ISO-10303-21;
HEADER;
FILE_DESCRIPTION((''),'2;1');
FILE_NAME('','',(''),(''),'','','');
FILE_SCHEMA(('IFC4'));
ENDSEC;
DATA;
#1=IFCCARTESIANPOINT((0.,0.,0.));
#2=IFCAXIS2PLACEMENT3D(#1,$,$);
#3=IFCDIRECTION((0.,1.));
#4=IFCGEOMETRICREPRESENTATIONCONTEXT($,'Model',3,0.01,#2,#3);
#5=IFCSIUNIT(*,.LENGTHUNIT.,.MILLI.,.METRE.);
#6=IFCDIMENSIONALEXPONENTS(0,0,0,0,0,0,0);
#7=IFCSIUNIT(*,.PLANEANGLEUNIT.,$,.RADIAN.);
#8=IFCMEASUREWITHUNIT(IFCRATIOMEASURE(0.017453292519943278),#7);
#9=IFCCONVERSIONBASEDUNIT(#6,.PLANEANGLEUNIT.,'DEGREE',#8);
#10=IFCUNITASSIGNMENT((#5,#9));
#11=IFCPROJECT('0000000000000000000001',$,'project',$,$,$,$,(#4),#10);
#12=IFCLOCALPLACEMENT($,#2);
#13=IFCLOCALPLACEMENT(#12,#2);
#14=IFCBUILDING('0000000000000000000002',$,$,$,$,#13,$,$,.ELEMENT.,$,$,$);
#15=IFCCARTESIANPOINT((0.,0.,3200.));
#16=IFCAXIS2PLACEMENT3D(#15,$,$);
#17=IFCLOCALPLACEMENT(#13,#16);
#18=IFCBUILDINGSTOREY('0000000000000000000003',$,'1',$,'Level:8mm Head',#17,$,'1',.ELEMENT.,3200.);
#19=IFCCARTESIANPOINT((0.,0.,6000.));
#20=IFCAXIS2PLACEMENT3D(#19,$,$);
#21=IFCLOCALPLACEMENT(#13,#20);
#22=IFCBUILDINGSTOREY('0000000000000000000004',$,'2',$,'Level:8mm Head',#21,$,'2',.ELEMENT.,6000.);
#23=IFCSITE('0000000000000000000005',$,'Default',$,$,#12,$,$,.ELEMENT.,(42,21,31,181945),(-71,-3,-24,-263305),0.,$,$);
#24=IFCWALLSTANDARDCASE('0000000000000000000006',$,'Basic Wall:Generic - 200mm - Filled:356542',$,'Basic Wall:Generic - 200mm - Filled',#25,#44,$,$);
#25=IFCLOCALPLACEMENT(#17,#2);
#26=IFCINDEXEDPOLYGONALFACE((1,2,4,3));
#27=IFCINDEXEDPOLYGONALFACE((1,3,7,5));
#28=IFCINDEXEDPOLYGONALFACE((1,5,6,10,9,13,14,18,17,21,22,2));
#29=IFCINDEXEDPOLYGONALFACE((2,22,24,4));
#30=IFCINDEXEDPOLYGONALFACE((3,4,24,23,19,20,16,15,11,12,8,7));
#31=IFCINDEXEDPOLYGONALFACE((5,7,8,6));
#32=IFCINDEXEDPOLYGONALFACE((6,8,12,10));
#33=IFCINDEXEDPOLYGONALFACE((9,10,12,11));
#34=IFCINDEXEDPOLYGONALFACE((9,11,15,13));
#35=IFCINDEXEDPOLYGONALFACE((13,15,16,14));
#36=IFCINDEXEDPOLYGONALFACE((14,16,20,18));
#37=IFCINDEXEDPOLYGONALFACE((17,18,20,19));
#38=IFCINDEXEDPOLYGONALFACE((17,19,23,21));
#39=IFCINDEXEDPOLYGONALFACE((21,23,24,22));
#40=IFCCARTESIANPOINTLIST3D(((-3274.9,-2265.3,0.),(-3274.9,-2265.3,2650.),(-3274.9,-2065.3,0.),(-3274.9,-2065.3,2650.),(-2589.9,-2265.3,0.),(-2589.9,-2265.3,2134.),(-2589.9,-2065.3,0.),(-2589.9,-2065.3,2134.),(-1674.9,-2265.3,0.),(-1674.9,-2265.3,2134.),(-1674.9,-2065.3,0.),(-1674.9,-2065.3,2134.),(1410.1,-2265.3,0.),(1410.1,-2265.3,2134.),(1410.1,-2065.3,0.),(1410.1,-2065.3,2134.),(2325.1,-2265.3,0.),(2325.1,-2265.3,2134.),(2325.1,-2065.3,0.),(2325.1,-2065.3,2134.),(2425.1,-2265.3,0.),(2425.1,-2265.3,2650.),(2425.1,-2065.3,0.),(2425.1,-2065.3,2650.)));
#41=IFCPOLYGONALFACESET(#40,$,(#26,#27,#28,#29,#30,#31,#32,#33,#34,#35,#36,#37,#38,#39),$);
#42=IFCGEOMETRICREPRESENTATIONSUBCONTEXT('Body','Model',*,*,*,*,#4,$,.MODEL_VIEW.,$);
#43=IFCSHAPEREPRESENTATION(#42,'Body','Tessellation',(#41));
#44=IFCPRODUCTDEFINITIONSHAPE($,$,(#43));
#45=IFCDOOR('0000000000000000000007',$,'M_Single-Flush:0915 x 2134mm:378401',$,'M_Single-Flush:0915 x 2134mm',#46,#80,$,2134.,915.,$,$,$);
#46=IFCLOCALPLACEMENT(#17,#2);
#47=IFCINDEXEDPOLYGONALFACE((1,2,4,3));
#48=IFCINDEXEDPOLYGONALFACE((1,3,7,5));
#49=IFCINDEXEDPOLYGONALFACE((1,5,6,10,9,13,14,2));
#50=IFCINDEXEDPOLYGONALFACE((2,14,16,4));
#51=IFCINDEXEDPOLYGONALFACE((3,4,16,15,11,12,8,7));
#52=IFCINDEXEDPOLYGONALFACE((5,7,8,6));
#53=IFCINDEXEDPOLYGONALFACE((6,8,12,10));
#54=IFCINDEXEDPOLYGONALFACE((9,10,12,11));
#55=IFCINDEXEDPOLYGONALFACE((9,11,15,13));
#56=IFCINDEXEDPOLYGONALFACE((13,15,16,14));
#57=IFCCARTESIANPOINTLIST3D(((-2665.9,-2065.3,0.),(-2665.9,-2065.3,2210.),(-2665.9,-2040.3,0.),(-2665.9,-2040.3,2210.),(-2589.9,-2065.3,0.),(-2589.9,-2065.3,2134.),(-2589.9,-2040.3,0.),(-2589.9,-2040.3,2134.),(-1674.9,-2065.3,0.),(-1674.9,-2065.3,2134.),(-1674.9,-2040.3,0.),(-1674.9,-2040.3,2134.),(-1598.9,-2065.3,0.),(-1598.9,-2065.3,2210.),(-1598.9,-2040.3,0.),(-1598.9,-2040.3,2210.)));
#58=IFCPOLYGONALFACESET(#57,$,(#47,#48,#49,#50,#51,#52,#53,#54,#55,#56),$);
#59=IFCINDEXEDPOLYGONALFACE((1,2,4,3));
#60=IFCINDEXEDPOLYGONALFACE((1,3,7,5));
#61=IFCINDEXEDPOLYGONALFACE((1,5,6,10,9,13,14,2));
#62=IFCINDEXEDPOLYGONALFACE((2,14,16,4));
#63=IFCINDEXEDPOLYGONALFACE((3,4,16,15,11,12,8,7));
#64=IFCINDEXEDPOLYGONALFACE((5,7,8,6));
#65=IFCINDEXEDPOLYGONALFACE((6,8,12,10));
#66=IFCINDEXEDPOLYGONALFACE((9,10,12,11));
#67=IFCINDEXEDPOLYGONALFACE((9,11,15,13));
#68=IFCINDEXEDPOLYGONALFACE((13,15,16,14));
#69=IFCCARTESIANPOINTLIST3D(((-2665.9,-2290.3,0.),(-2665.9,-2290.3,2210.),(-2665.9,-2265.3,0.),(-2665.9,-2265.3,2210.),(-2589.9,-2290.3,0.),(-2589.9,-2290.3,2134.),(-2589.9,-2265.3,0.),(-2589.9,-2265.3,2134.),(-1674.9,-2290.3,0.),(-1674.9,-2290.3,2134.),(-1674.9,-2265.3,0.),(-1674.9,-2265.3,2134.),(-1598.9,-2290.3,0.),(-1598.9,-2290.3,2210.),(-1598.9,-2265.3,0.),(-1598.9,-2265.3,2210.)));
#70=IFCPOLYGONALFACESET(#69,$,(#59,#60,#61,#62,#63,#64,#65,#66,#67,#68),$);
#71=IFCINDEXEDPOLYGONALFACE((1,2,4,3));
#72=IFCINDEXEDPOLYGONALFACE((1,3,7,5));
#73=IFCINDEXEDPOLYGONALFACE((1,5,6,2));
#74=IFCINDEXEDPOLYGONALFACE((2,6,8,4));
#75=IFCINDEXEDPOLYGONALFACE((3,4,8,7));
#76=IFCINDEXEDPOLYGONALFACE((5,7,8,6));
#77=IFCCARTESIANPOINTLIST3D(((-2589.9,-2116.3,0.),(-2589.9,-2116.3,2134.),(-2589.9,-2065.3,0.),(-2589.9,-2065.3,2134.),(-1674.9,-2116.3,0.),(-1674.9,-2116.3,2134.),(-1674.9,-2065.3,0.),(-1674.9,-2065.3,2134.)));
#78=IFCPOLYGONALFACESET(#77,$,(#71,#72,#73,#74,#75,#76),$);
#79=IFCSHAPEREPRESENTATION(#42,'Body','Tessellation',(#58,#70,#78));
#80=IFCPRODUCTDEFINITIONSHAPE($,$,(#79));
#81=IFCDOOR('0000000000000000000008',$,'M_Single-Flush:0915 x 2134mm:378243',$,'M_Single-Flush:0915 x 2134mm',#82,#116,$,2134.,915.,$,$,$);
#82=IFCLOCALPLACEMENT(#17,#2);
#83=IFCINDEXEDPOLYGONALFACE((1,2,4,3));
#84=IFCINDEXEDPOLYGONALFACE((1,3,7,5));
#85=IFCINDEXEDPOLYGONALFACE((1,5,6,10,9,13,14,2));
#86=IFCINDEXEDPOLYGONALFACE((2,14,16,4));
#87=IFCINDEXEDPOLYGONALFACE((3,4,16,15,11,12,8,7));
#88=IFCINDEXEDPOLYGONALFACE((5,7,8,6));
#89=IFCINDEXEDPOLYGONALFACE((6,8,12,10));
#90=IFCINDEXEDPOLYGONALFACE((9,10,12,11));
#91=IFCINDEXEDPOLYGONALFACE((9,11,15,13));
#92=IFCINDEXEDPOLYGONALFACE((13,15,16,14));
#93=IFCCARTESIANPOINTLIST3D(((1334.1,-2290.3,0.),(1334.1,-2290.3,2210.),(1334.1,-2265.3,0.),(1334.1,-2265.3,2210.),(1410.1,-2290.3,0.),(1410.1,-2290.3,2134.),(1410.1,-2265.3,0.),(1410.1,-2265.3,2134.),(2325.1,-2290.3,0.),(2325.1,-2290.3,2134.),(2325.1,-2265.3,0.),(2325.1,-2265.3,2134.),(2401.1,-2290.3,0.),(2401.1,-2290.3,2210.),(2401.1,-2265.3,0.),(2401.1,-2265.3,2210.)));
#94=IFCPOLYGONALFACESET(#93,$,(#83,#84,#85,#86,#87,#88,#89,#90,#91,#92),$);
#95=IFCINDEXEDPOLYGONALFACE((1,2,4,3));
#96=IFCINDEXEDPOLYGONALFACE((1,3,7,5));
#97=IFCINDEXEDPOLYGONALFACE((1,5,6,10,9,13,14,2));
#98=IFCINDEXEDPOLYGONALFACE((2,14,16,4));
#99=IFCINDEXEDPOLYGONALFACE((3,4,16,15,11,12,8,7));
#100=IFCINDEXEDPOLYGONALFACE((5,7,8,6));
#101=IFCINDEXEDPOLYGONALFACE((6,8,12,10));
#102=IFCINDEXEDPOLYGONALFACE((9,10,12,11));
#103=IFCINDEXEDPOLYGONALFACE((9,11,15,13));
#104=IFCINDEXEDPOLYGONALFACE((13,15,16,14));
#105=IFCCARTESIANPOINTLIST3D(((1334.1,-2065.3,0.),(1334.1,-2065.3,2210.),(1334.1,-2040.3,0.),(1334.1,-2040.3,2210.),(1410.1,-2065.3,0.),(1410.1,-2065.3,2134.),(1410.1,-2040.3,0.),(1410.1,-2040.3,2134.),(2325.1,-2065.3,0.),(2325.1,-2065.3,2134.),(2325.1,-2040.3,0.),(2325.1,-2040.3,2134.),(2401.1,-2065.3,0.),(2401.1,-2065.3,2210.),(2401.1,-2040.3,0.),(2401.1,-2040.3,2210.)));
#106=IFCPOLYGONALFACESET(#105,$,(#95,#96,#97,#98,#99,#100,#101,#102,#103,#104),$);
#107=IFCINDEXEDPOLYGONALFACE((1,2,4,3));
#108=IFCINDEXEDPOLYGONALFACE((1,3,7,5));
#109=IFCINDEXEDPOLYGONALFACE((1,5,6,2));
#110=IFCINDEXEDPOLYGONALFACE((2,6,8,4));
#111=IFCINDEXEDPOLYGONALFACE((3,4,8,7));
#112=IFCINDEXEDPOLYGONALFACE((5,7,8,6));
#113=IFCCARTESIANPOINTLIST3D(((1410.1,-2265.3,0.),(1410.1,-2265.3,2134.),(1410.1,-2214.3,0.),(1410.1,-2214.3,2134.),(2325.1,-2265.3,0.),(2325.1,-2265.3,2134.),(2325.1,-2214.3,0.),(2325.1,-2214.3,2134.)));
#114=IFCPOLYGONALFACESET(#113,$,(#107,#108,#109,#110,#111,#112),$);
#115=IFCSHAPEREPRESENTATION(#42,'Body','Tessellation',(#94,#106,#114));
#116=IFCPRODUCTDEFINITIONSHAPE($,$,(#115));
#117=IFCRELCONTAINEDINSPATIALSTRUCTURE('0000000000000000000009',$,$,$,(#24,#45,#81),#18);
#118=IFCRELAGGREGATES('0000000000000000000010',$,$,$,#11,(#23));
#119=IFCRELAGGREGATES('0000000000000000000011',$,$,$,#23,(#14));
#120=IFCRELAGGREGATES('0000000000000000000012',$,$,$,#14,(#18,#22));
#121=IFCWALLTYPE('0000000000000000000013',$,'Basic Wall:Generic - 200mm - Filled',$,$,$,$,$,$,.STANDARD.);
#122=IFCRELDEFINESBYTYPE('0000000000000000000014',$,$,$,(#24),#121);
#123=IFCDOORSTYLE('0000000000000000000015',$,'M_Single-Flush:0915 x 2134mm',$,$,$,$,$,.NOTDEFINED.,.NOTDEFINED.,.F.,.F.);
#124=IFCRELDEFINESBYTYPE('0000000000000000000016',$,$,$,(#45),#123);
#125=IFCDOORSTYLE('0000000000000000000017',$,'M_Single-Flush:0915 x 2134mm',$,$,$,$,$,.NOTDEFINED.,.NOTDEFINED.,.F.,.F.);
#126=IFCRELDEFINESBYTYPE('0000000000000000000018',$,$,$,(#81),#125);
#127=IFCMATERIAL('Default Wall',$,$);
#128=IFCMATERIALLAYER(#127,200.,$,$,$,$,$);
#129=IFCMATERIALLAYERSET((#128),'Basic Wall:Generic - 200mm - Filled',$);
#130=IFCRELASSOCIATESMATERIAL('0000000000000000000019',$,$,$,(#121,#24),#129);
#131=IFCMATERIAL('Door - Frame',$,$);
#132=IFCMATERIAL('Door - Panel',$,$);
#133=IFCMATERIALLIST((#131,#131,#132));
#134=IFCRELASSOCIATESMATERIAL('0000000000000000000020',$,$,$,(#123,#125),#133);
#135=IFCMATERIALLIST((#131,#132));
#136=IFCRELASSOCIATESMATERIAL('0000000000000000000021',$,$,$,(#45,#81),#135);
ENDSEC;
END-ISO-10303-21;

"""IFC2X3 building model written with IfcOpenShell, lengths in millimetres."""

from ifc_helpers import new_model, entity, si_unit, converted_unit, direction, frame, frame_2d, origin, place, context, subcontext, project, spatial, polyline, rectangle, outline, extrude, clip, bounded_halfspace, source, transform, mapped, material, material_list, layer, layer_set, layer_usage, type_object, type_shapes, element, fill, save


model = new_model("IFC2X3")

# Units and contexts
model_context = context("Model", 3, precision=0.01, world=origin(), true_north=direction((0.0, 1.0)))
body_context = subcontext(model_context, "Body", "Model", "MODEL_VIEW")
ifc_project = project(units=[si_unit("LENGTHUNIT", "METRE", prefix="MILLI"), converted_unit("PLANEANGLEUNIT", "DEGREE", entity("IfcRatioMeasure", 0.017453292519943278), si_unit("PLANEANGLEUNIT", "RADIAN"), dimensions=[0, 0, 0, 0, 0, 0, 0])], contexts=[model_context])

# Site, building, storey
site_placement = place(None, origin())
site = spatial("IfcSite", under=ifc_project, at=site_placement, Name="Default", CompositionType="ELEMENT", RefLatitude=(42, 21, 31, 181945), RefLongitude=(-71, -3, -24, -263305), RefElevation=0.0)
building_placement = place(site_placement, origin())
building = spatial("IfcBuilding", under=site, at=building_placement, CompositionType="ELEMENT")
storey_1_placement = place(building_placement, frame((0.0, 0.0, 3200.0)))
storey_1 = spatial("IfcBuildingStorey", under=building, at=storey_1_placement, Name="1", ObjectType="Level:8mm Head", LongName="1", CompositionType="ELEMENT", Elevation=3200.0)

# Shared definitions
ifc_material_1 = material(Name="Default Wall")

# Shared definitions
storey_2_placement = place(building_placement, frame((0.0, 0.0, 6000.0)))
storey_2 = spatial("IfcBuildingStorey", under=building, at=storey_2_placement, Name="2", ObjectType="Level:8mm Head", LongName="2", CompositionType="ELEMENT", Elevation=6000.0)

# Shared definitions
ifc_layer_1 = layer(ifc_material_1, 200.0)
ifc_layer_set_1 = layer_set([ifc_layer_1], Name="Basic Wall:Generic - 200mm - Filled")
ifc_layer_usage_1 = layer_usage(ifc_layer_set_1, "AXIS2", "NEGATIVE", 100.0)
wall_type_1 = type_object("IfcWallType", Name="Basic Wall:Generic - 200mm - Filled", PredefinedType="STANDARD", material=ifc_layer_set_1)

# Wall, openings, doors
wall_1_placement = place(storey_1_placement, frame((2425.1, -2165.3, 0.0), z_axis=(0.0, 0.0, 1.0), x_axis=(-1.0, 0.0, 0.0)))
wall_1 = element("IfcWallStandardCase", 1, at=wall_1_placement, inside=storey_1, type_object=wall_type_1, material=ifc_layer_usage_1, Name="Basic Wall:Generic - 200mm - Filled:356542", ObjectType="Basic Wall:Generic - 200mm - Filled", context=body_context, shape_type="Clipping", body=[
    clip(extrude(rectangle(XDim=5700.0, YDim=200.0, at=frame_2d((2850.0, 0.0), x_axis=(1.0, 0.0))), origin(), (0.0, 0.0, 1.0), 2650.0), bounded_halfspace(frame((0.0, -100.0, 2650.0), z_axis=(0.0, 0.0, -1.0), x_axis=(0.0, 1.0, 0.0)), True, frame((0.0, -100.0, 2650.0)), polyline([(0.0, 0.0), (1737360.0, 0.0), (1737360.0, 60960.0), (1036320.0, 60960.0), (975360.0, 60960.0), (365760.0, 60960.0), (335280.0, 60960.0), (0.0, 60960.0), (0.0, 0.0)]))),
])
opening_1_placement = place(wall_1_placement, frame((100.0, -100.0, 0.0)))
opening_1 = element("IfcOpeningElement", 2, at=opening_1_placement, cuts=wall_1, ObjectType="Opening", context=body_context, shape_type="SweptSolid", body=[
    extrude(rectangle(XDim=915.0, YDim=2134.0, at=frame_2d((1067.0, 457.5), x_axis=(0.0, 1.0))), frame((0.0, 0.0, 0.0), z_axis=(0.0, 1.0, 0.0), x_axis=(0.0, 0.0, 1.0)), (0.0, 0.0, 1.0), 200.0),
])
opening_2_placement = place(wall_1_placement, frame((5015.0, 100.0, 0.0)))
opening_2 = element("IfcOpeningElement", 3, at=opening_2_placement, cuts=wall_1, ObjectType="Opening", context=body_context, shape_type="SweptSolid", body=[
    extrude(rectangle(XDim=915.0, YDim=2134.0, at=frame_2d((1067.0, 457.5), x_axis=(0.0, -1.0))), frame((0.0, 0.0, 0.0), z_axis=(0.0, -1.0, 0.0), x_axis=(0.0, 0.0, 1.0)), (0.0, 0.0, 1.0), 200.0),
])
ifc_material_2 = material(Name="Door - Frame")
ifc_material_3 = material(Name="Door - Panel")
ifc_material_list_1 = material_list([ifc_material_2, ifc_material_3])
ifc_material_list_2 = material_list([ifc_material_2, ifc_material_2, ifc_material_3])
door_style_1 = type_object("IfcDoorStyle", Name="M_Single-Flush:0915 x 2134mm", ConstructionType="NOTDEFINED", OperationType="NOTDEFINED", ParameterTakesPrecedence=False, Sizeable=False, material=ifc_material_list_2)
shared_shape_1 = source(origin(), body_context, "Body", "SweptSolid", [
    extrude(outline(polyline([(-533.5, -1124.0), (533.5, -1124.0), (533.5, 1086.0), (457.5, 1086.0), (457.5, -1048.0), (-457.5, -1048.0), (-457.5, 1086.0), (-533.5, 1086.0), (-533.5, -1124.0)])), frame((457.5, 225.0, 1086.0), z_axis=(0.0, -1.0, 0.0), x_axis=(-1.0, 0.0, 0.0)), (0.0, 0.0, 1.0), 25.0),
    extrude(outline(polyline([(-1124.0, -533.5), (1086.0, -533.5), (1086.0, -457.5), (-1048.0, -457.5), (-1048.0, 457.5), (1086.0, 457.5), (1086.0, 533.5), (-1124.0, 533.5), (-1124.0, -533.5)])), frame((457.5, 0.0, 1086.0), z_axis=(0.0, -1.0, 0.0), x_axis=(0.0, 0.0, -1.0)), (0.0, 0.0, 1.0), 25.0),
    extrude(rectangle(XDim=915.0, YDim=51.0, at=frame_2d((0.0, 0.0), x_axis=(1.0, 0.0))), frame((457.5, 174.5, 0.0)), (0.0, 0.0, 1.0), 2134.0),
])
type_shapes(door_style_1, [shared_shape_1])
door_1_placement = place(opening_2_placement, frame((0.0, 0.0, 0.0), z_axis=(0.0, 0.0, 1.0), x_axis=(-1.0, 0.0, 0.0)))
door_1 = element("IfcDoor", 4, at=door_1_placement, inside=storey_1, type_object=door_style_1, material=ifc_material_list_1, Name="M_Single-Flush:0915 x 2134mm:378401", ObjectType="M_Single-Flush:0915 x 2134mm", OverallHeight=2134.0, OverallWidth=915.0, context=body_context, shape_type="MappedRepresentation", body=[
    mapped(shared_shape_1, transform((0.0, 0.0, 0.0), scale=1.0)),
])
fill(opening_2, door_1)
door_style_2 = type_object("IfcDoorStyle", Name="M_Single-Flush:0915 x 2134mm", ConstructionType="NOTDEFINED", OperationType="NOTDEFINED", ParameterTakesPrecedence=False, Sizeable=False, material=ifc_material_list_2)
shared_shape_2 = source(origin(), body_context, "Body", "SweptSolid", [
    extrude(outline(polyline([(-533.5, -1124.0), (533.5, -1124.0), (533.5, 1086.0), (457.5, 1086.0), (457.5, -1048.0), (-457.5, -1048.0), (-457.5, 1086.0), (-533.5, 1086.0), (-533.5, -1124.0)])), frame((457.5, 200.0, 1086.0), z_axis=(0.0, 1.0, 0.0), x_axis=(1.0, 0.0, 0.0)), (0.0, 0.0, 1.0), 25.0),
    extrude(outline(polyline([(-1124.0, -533.5), (1086.0, -533.5), (1086.0, -457.5), (-1048.0, -457.5), (-1048.0, 457.5), (1086.0, 457.5), (1086.0, 533.5), (-1124.0, 533.5), (-1124.0, -533.5)])), frame((457.5, -25.0, 1086.0), z_axis=(0.0, 1.0, 0.0), x_axis=(0.0, 0.0, -1.0)), (0.0, 0.0, 1.0), 25.0),
    extrude(rectangle(XDim=51.0, YDim=915.0, at=frame_2d((0.0, 0.0), x_axis=(1.0, 0.0))), frame((457.5, 174.5, 0.0), z_axis=(0.0, 0.0, 1.0), x_axis=(0.0, 1.0, 0.0)), (0.0, 0.0, 1.0), 2134.0),
])
type_shapes(door_style_2, [shared_shape_2])
door_2_placement = place(opening_1_placement, origin())
door_2 = element("IfcDoor", 5, at=door_2_placement, inside=storey_1, type_object=door_style_2, material=ifc_material_list_1, Name="M_Single-Flush:0915 x 2134mm:378243", ObjectType="M_Single-Flush:0915 x 2134mm", OverallHeight=2134.0, OverallWidth=915.0, context=body_context, shape_type="MappedRepresentation", body=[
    mapped(shared_shape_2, transform((0.0, 0.0, 0.0), scale=1.0)),
])
fill(opening_1, door_2)

save(model, "model.ifc")
